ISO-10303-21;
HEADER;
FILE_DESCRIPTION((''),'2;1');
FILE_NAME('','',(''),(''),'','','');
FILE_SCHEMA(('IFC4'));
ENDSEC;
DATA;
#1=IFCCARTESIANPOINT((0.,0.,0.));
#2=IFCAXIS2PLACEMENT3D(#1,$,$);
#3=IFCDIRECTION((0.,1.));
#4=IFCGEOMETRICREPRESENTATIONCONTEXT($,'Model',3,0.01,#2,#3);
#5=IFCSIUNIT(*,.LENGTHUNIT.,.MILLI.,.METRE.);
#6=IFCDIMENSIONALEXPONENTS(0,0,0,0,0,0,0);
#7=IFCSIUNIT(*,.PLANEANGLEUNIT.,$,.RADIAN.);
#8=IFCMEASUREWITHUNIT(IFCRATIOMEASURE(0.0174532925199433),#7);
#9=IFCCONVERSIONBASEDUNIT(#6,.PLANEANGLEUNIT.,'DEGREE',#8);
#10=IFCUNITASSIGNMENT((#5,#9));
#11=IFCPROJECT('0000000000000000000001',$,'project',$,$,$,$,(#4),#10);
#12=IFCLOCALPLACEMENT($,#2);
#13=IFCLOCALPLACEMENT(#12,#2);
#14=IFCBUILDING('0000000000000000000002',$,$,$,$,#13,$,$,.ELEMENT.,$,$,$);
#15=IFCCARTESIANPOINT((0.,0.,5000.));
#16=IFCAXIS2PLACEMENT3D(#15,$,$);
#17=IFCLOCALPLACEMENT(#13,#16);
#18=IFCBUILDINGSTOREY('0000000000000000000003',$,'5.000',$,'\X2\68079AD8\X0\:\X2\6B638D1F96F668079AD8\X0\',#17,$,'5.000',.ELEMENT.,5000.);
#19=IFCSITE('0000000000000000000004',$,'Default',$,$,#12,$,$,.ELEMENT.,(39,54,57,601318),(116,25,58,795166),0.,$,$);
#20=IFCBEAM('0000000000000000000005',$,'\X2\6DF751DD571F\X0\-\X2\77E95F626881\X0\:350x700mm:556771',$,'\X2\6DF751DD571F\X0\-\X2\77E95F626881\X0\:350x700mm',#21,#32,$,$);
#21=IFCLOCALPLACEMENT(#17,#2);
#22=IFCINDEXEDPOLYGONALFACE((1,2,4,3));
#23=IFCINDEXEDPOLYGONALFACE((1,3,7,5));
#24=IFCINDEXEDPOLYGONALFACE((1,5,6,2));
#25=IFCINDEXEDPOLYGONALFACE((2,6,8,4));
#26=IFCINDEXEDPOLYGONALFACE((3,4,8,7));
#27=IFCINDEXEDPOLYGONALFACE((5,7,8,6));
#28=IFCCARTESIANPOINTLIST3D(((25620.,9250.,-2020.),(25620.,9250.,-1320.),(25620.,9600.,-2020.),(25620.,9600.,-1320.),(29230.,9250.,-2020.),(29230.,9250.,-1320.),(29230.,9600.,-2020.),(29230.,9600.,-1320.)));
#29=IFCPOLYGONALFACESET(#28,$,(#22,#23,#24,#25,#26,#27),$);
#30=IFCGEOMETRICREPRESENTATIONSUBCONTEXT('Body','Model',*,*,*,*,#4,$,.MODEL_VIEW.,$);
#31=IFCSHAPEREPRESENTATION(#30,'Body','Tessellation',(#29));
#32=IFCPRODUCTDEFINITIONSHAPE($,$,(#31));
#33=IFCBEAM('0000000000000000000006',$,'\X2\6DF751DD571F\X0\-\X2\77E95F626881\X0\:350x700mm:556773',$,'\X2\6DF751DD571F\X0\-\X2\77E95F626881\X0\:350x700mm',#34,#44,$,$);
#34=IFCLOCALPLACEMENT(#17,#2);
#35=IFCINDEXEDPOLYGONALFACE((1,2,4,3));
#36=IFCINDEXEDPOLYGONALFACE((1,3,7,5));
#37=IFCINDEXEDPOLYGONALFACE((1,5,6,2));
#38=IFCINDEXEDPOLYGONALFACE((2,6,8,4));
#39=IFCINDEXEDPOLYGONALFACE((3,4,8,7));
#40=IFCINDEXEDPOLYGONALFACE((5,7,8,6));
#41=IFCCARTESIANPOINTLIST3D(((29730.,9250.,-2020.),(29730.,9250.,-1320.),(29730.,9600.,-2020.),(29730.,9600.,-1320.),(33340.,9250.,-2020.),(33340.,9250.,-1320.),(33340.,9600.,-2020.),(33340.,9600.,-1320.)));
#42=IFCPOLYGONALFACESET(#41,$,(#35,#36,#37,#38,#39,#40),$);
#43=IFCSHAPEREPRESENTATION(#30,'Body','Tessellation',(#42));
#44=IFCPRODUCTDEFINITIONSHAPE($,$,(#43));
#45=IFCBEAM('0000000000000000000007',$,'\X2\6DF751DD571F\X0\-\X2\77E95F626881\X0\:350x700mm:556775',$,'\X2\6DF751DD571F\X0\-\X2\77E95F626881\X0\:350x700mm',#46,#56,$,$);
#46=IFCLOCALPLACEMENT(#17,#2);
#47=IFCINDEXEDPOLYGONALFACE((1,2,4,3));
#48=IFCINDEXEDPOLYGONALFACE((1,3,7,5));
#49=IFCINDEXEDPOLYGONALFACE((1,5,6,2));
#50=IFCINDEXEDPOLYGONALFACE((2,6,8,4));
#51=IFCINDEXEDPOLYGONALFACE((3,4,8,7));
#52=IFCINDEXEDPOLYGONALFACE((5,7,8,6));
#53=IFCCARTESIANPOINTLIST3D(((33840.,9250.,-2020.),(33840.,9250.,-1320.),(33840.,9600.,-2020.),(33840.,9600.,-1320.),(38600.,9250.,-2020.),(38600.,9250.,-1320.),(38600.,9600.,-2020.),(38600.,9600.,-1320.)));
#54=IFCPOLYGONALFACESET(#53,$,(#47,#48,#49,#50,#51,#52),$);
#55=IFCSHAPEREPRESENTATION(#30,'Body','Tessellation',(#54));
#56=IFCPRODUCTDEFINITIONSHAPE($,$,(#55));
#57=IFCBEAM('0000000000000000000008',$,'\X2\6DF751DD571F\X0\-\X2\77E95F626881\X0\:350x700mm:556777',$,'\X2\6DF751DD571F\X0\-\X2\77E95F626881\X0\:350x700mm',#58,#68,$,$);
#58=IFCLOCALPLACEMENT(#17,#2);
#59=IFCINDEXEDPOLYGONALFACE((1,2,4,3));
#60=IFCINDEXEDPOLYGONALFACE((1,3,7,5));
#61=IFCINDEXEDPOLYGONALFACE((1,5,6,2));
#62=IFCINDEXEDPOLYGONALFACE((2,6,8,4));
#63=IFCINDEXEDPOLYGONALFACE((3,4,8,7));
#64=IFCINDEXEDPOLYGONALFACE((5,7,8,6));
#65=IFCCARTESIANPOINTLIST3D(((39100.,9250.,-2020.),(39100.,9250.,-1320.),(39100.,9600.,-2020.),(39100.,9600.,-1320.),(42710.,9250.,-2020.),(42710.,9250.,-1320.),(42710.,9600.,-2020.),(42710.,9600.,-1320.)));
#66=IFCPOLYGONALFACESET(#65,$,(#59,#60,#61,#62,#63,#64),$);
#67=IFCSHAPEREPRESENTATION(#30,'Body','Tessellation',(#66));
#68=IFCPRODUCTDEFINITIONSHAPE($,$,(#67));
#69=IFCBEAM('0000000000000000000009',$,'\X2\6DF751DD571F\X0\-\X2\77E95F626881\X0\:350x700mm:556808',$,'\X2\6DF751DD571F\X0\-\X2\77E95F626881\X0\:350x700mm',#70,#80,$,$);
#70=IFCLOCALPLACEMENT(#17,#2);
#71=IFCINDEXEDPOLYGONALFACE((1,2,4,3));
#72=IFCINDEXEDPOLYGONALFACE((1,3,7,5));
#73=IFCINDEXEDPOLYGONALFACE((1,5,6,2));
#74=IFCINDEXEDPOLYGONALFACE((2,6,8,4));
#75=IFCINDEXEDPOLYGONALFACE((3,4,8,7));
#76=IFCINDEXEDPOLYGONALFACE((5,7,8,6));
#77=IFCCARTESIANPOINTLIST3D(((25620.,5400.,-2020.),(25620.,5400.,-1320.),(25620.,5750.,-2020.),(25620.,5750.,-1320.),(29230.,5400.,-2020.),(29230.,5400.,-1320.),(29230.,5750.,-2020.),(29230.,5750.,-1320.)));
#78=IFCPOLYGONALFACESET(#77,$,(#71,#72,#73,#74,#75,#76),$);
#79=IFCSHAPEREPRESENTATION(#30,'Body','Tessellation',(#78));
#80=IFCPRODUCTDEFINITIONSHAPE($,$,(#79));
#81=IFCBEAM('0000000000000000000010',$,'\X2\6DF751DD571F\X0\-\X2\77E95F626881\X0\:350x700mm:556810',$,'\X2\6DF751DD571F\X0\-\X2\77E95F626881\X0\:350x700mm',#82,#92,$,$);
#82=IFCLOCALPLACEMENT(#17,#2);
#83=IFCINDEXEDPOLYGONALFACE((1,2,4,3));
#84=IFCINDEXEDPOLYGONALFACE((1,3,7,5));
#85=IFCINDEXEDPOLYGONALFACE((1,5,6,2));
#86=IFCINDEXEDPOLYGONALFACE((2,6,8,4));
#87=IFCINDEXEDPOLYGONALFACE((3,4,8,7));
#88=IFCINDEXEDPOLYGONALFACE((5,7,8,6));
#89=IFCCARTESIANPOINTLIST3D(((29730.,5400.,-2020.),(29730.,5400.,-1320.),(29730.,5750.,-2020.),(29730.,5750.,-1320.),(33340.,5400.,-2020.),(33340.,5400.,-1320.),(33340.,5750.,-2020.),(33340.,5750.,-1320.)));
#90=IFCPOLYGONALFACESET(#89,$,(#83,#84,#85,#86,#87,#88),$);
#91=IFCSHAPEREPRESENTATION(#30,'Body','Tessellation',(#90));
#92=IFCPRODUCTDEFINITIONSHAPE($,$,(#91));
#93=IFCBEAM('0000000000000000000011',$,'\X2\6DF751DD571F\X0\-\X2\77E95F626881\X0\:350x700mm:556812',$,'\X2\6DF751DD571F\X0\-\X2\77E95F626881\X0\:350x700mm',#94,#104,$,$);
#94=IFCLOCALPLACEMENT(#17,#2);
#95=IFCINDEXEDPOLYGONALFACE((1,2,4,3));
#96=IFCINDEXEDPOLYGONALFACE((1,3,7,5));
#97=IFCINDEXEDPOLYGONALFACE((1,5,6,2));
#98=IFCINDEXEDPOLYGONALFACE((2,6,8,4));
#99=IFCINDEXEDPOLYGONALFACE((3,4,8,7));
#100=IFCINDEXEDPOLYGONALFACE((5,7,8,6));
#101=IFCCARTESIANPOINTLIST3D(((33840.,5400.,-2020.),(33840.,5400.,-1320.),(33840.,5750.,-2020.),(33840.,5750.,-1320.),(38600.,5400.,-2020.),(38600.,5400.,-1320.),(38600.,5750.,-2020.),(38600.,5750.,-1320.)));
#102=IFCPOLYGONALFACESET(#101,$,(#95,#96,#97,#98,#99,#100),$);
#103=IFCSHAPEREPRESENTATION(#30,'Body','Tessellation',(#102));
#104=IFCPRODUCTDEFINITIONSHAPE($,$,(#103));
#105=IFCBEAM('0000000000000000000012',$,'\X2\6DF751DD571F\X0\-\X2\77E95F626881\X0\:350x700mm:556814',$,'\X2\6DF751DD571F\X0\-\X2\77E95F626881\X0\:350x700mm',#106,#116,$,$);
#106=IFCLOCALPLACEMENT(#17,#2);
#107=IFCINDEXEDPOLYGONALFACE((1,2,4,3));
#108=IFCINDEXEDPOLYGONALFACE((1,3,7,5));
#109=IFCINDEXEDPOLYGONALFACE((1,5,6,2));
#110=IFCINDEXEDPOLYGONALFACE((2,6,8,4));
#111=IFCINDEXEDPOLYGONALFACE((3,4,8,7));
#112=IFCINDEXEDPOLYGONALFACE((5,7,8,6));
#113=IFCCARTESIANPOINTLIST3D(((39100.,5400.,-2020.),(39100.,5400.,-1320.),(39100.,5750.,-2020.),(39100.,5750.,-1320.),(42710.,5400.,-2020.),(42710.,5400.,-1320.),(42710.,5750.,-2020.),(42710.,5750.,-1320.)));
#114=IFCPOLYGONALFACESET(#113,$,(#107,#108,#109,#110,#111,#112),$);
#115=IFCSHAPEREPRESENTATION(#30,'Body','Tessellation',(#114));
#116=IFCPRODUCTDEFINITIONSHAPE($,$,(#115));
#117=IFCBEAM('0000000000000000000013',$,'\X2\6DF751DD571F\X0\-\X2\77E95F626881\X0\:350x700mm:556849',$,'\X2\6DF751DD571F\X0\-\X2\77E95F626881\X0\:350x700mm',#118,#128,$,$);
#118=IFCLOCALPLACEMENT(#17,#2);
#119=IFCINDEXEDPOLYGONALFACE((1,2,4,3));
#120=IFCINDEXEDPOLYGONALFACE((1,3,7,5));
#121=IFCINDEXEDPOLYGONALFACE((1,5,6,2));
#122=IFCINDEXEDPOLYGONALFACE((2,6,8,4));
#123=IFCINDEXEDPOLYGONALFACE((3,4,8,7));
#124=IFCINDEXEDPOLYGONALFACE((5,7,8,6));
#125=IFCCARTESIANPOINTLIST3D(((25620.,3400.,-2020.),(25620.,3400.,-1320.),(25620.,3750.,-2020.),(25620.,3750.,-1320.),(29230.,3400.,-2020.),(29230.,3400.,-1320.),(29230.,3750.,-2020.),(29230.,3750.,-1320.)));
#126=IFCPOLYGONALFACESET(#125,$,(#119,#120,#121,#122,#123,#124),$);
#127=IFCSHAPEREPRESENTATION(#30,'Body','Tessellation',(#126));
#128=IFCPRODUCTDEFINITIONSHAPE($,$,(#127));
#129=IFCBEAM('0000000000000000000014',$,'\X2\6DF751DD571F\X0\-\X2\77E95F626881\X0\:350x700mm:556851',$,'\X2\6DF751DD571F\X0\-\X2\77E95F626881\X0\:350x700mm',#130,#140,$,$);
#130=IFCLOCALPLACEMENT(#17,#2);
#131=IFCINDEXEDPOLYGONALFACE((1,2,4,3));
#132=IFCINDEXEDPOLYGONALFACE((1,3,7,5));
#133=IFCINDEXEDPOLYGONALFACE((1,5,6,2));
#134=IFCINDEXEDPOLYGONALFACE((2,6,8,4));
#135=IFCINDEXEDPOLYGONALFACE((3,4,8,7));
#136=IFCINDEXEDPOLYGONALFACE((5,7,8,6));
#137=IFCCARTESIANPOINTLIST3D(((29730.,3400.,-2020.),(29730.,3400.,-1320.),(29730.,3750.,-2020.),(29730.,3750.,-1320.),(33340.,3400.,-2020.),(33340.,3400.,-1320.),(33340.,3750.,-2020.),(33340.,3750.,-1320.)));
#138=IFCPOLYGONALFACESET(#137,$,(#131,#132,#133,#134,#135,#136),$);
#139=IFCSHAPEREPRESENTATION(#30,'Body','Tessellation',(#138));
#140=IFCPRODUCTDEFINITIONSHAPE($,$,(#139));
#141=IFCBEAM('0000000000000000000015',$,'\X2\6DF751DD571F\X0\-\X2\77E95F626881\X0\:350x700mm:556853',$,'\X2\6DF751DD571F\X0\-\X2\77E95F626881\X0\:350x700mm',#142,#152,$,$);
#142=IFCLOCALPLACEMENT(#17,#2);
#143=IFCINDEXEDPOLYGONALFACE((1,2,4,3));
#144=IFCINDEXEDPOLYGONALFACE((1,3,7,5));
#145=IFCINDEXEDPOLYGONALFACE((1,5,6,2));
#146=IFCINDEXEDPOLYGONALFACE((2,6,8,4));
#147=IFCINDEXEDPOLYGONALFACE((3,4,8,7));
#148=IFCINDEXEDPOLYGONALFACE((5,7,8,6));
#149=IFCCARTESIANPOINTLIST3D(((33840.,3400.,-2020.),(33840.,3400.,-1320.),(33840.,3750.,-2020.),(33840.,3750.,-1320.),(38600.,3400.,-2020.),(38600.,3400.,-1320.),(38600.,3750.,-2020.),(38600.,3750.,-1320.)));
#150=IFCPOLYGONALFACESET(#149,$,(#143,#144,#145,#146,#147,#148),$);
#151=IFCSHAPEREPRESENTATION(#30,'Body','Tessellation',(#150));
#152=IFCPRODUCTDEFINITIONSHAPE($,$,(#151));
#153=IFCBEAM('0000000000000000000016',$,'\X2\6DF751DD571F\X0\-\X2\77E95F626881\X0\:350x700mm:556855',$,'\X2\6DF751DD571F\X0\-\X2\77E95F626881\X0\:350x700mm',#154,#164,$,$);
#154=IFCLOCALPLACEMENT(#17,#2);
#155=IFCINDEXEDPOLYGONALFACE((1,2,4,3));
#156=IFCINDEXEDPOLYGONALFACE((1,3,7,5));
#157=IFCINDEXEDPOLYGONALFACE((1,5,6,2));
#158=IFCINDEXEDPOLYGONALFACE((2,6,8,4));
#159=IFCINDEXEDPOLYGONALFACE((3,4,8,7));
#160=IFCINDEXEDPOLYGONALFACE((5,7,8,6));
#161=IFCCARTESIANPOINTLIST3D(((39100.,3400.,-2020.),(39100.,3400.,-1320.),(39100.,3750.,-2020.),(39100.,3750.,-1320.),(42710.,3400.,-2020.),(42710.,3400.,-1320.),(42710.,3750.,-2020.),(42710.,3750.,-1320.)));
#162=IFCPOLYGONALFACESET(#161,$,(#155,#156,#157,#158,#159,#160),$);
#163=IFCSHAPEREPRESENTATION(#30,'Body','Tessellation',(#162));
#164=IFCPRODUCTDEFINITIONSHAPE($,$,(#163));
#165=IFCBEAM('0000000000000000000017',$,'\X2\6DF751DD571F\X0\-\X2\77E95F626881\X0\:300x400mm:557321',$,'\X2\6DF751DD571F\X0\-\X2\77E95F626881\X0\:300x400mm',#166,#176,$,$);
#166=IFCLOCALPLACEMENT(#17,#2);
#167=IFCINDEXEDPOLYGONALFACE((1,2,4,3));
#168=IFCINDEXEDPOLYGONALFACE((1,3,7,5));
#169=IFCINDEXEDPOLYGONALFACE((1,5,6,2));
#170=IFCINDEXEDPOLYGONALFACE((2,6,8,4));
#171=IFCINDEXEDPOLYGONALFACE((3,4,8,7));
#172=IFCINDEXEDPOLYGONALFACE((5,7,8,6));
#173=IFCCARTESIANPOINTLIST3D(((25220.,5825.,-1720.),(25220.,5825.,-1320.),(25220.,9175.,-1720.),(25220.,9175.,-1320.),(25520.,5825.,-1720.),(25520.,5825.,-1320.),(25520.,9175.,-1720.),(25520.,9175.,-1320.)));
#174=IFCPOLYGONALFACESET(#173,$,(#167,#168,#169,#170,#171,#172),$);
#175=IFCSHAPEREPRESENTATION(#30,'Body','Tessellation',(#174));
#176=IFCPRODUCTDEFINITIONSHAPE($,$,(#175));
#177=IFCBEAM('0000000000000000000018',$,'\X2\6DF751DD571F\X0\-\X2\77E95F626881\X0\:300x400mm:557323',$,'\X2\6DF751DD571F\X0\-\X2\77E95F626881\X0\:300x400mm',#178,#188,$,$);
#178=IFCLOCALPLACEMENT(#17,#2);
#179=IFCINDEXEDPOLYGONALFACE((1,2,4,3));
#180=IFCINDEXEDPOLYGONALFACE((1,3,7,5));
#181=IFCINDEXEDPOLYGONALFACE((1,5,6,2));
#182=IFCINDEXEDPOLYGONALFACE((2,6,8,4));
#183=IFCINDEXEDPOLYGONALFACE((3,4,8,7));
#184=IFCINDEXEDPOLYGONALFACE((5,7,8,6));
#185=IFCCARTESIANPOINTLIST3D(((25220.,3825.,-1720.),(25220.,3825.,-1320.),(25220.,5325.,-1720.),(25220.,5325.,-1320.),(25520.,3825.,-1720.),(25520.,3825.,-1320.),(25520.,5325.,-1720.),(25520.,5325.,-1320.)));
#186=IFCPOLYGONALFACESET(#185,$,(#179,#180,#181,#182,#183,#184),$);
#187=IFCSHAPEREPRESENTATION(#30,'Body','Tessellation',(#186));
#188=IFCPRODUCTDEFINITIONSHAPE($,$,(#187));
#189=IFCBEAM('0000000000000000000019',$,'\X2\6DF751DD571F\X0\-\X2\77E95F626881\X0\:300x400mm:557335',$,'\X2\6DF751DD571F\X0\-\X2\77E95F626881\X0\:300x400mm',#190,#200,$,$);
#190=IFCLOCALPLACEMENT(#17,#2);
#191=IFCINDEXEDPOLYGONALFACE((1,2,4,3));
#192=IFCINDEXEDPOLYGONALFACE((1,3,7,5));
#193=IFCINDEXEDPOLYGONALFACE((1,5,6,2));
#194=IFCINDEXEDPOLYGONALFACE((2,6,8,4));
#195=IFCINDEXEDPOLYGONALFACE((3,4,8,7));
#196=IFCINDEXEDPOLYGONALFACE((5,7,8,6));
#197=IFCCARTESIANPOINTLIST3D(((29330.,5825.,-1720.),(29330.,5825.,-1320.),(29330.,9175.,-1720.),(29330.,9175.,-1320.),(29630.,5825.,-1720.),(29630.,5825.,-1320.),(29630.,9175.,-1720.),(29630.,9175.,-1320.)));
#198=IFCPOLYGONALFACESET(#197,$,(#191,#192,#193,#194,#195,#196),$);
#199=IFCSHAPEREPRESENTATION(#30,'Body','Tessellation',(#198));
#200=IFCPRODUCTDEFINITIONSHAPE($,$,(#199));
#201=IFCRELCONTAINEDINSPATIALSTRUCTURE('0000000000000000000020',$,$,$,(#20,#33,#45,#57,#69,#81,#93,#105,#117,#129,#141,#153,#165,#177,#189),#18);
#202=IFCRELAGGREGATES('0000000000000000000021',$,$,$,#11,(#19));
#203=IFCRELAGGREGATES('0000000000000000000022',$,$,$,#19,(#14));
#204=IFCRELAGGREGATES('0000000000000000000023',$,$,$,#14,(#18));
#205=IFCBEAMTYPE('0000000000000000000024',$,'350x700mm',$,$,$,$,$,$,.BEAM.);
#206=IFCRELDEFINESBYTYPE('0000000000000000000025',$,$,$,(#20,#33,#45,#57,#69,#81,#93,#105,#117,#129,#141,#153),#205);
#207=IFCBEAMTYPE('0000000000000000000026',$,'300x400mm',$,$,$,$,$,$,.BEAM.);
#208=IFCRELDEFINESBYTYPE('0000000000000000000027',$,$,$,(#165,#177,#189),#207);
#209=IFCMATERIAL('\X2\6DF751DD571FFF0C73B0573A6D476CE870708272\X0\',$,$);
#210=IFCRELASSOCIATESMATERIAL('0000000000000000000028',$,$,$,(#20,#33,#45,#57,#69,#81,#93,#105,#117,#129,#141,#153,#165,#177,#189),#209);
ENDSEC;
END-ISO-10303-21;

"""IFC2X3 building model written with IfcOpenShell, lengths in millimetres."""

from ifc_helpers import new_model, entity, si_unit, converted_unit, direction, frame, frame_2d, origin, place, context, subcontext, project, spatial, rectangle, extrude, material, type_object, element, save


model = new_model("IFC2X3")

# Units and contexts
model_context = context("Model", 3, precision=0.01, world=origin(), true_north=direction((0.0, 1.0)))
body_context = subcontext(model_context, "Body", "Model", "MODEL_VIEW")
ifc_project = project(units=[si_unit("LENGTHUNIT", "METRE", prefix="MILLI"), converted_unit("PLANEANGLEUNIT", "DEGREE", entity("IfcRatioMeasure", 0.0174532925199433), si_unit("PLANEANGLEUNIT", "RADIAN"), dimensions=[0, 0, 0, 0, 0, 0, 0])], contexts=[model_context])

# Site, building, storey
site_placement = place(None, origin())
site = spatial("IfcSite", under=ifc_project, at=site_placement, Name="Default", CompositionType="ELEMENT", RefLatitude=(39, 54, 57, 601318), RefLongitude=(116, 25, 58, 795166), RefElevation=0.0)
building_placement = place(site_placement, origin())
building = spatial("IfcBuilding", under=site, at=building_placement, CompositionType="ELEMENT")
storey_placement = place(building_placement, frame((0.0, 0.0, 5000.0)))
storey = spatial("IfcBuildingStorey", under=building, at=storey_placement, Name="5.000", ObjectType="标高:正负零标高", LongName="5.000", CompositionType="ELEMENT", Elevation=5000.0)

# Beams
ifc_material_1 = material(Name="混凝土，现场浇注灰色")
beam_type_1 = type_object("IfcBeamType", Name="350x700mm", PredefinedType="BEAM")
for number, where, name in (
    (1, (25620.0, 9425.0, -1320.0), "混凝土-矩形梁:350x700mm:556771"),
    (2, (29730.0, 9425.0, -1320.0), "混凝土-矩形梁:350x700mm:556773"),
):
    element("IfcBeam", number, at=place(storey_placement, frame(where)), inside=storey, type_object=beam_type_1, material=ifc_material_1, Name=name, ObjectType="混凝土-矩形梁:350x700mm", context=body_context, shape_type="SweptSolid", body=[
        extrude(rectangle(XDim=700.0, YDim=350.0, at=frame_2d((0.0, 0.0), x_axis=(1.0, 0.0))), frame((0.0, 0.0, -350.0), z_axis=(1.0, 0.0, 0.0), x_axis=(0.0, 0.0, -1.0)), (0.0, 0.0, 1.0), 3610.0),
    ])
beam_1_placement = place(storey_placement, frame((33840.0, 9425.0, -1320.0)))
element("IfcBeam", 3, at=beam_1_placement, inside=storey, type_object=beam_type_1, material=ifc_material_1, Name="混凝土-矩形梁:350x700mm:556775", ObjectType="混凝土-矩形梁:350x700mm", context=body_context, shape_type="SweptSolid", body=[
    extrude(rectangle(XDim=700.0, YDim=350.0, at=frame_2d((0.0, 0.0), x_axis=(1.0, 0.0))), frame((0.0, 0.0, -350.0), z_axis=(1.0, 0.0, 0.0), x_axis=(0.0, 0.0, -1.0)), (0.0, 0.0, 1.0), 4760.0),
])
beam_2_placement = place(storey_placement, frame((39100.0, 9425.0, -1320.0)))
element("IfcBeam", 4, at=beam_2_placement, inside=storey, type_object=beam_type_1, material=ifc_material_1, Name="混凝土-矩形梁:350x700mm:556777", ObjectType="混凝土-矩形梁:350x700mm", context=body_context, shape_type="SweptSolid", body=[
    extrude(rectangle(XDim=700.0, YDim=350.0, at=frame_2d((0.0, 0.0), x_axis=(1.0, 0.0))), frame((0.0, 0.0, -350.0), z_axis=(1.0, 0.0, 0.0), x_axis=(0.0, 0.0, -1.0)), (0.0, 0.0, 1.0), 3610.0),
])
for number, where, name in (
    (5, (25620.0, 5575.0, -1320.0), "混凝土-矩形梁:350x700mm:556808"),
    (6, (29730.0, 5575.0, -1320.0), "混凝土-矩形梁:350x700mm:556810"),
):
    element("IfcBeam", number, at=place(storey_placement, frame(where)), inside=storey, type_object=beam_type_1, material=ifc_material_1, Name=name, ObjectType="混凝土-矩形梁:350x700mm", context=body_context, shape_type="SweptSolid", body=[
        extrude(rectangle(XDim=700.0, YDim=350.0, at=frame_2d((0.0, 0.0), x_axis=(1.0, 0.0))), frame((0.0, 0.0, -350.0), z_axis=(1.0, 0.0, 0.0), x_axis=(0.0, 0.0, -1.0)), (0.0, 0.0, 1.0), 3610.0),
    ])
beam_3_placement = place(storey_placement, frame((33840.0, 5575.0, -1320.0)))
element("IfcBeam", 7, at=beam_3_placement, inside=storey, type_object=beam_type_1, material=ifc_material_1, Name="混凝土-矩形梁:350x700mm:556812", ObjectType="混凝土-矩形梁:350x700mm", context=body_context, shape_type="SweptSolid", body=[
    extrude(rectangle(XDim=700.0, YDim=350.0, at=frame_2d((0.0, 0.0), x_axis=(1.0, 0.0))), frame((0.0, 0.0, -350.0), z_axis=(1.0, 0.0, 0.0), x_axis=(0.0, 0.0, -1.0)), (0.0, 0.0, 1.0), 4760.0),
])
beam_4_placement = place(storey_placement, frame((39100.0, 5575.0, -1320.0)))
element("IfcBeam", 8, at=beam_4_placement, inside=storey, type_object=beam_type_1, material=ifc_material_1, Name="混凝土-矩形梁:350x700mm:556814", ObjectType="混凝土-矩形梁:350x700mm", context=body_context, shape_type="SweptSolid", body=[
    extrude(rectangle(XDim=700.0, YDim=350.0, at=frame_2d((0.0, 0.0), x_axis=(1.0, 0.0))), frame((0.0, 0.0, -350.0), z_axis=(1.0, 0.0, 0.0), x_axis=(0.0, 0.0, -1.0)), (0.0, 0.0, 1.0), 3610.0),
])
for number, where, name in (
    (9, (25620.0, 3575.0, -1320.0), "混凝土-矩形梁:350x700mm:556849"),
    (10, (29730.0, 3575.0, -1320.0), "混凝土-矩形梁:350x700mm:556851"),
):
    element("IfcBeam", number, at=place(storey_placement, frame(where)), inside=storey, type_object=beam_type_1, material=ifc_material_1, Name=name, ObjectType="混凝土-矩形梁:350x700mm", context=body_context, shape_type="SweptSolid", body=[
        extrude(rectangle(XDim=700.0, YDim=350.0, at=frame_2d((0.0, 0.0), x_axis=(1.0, 0.0))), frame((0.0, 0.0, -350.0), z_axis=(1.0, 0.0, 0.0), x_axis=(0.0, 0.0, -1.0)), (0.0, 0.0, 1.0), 3610.0),
    ])
beam_5_placement = place(storey_placement, frame((33840.0, 3575.0, -1320.0)))
element("IfcBeam", 11, at=beam_5_placement, inside=storey, type_object=beam_type_1, material=ifc_material_1, Name="混凝土-矩形梁:350x700mm:556853", ObjectType="混凝土-矩形梁:350x700mm", context=body_context, shape_type="SweptSolid", body=[
    extrude(rectangle(XDim=700.0, YDim=350.0, at=frame_2d((0.0, 0.0), x_axis=(1.0, 0.0))), frame((0.0, 0.0, -350.0), z_axis=(1.0, 0.0, 0.0), x_axis=(0.0, 0.0, -1.0)), (0.0, 0.0, 1.0), 4760.0),
])
beam_6_placement = place(storey_placement, frame((39100.0, 3575.0, -1320.0)))
element("IfcBeam", 12, at=beam_6_placement, inside=storey, type_object=beam_type_1, material=ifc_material_1, Name="混凝土-矩形梁:350x700mm:556855", ObjectType="混凝土-矩形梁:350x700mm", context=body_context, shape_type="SweptSolid", body=[
    extrude(rectangle(XDim=700.0, YDim=350.0, at=frame_2d((0.0, 0.0), x_axis=(1.0, 0.0))), frame((0.0, 0.0, -350.0), z_axis=(1.0, 0.0, 0.0), x_axis=(0.0, 0.0, -1.0)), (0.0, 0.0, 1.0), 3610.0),
])
beam_type_2 = type_object("IfcBeamType", Name="300x400mm", PredefinedType="BEAM")
beam_7_placement = place(storey_placement, frame((25370.0, 9175.0, -1320.0), z_axis=(0.0, 0.0, 1.0), x_axis=(0.0, -1.0, 0.0)))
element("IfcBeam", 13, at=beam_7_placement, inside=storey, type_object=beam_type_2, material=ifc_material_1, Name="混凝土-矩形梁:300x400mm:557321", ObjectType="混凝土-矩形梁:300x400mm", context=body_context, shape_type="SweptSolid", body=[
    extrude(rectangle(XDim=400.0, YDim=300.0, at=frame_2d((0.0, 0.0), x_axis=(1.0, 0.0))), frame((0.0, 0.0, -200.0), z_axis=(1.0, 0.0, 0.0), x_axis=(0.0, 0.0, -1.0)), (0.0, 0.0, 1.0), 3350.0),
])
beam_8_placement = place(storey_placement, frame((25370.0, 5325.0, -1320.0), z_axis=(0.0, 0.0, 1.0), x_axis=(0.0, -1.0, 0.0)))
element("IfcBeam", 14, at=beam_8_placement, inside=storey, type_object=beam_type_2, material=ifc_material_1, Name="混凝土-矩形梁:300x400mm:557323", ObjectType="混凝土-矩形梁:300x400mm", context=body_context, shape_type="SweptSolid", body=[
    extrude(rectangle(XDim=400.0, YDim=300.0, at=frame_2d((0.0, 0.0), x_axis=(1.0, 0.0))), frame((0.0, 0.0, -200.0), z_axis=(1.0, 0.0, 0.0), x_axis=(0.0, 0.0, -1.0)), (0.0, 0.0, 1.0), 1500.0),
])
beam_9_placement = place(storey_placement, frame((29480.0, 9175.0, -1320.0), z_axis=(0.0, 0.0, 1.0), x_axis=(0.0, -1.0, 0.0)))
element("IfcBeam", 15, at=beam_9_placement, inside=storey, type_object=beam_type_2, material=ifc_material_1, Name="混凝土-矩形梁:300x400mm:557335", ObjectType="混凝土-矩形梁:300x400mm", context=body_context, shape_type="SweptSolid", body=[
    extrude(rectangle(XDim=400.0, YDim=300.0, at=frame_2d((0.0, 0.0), x_axis=(1.0, 0.0))), frame((0.0, 0.0, -200.0), z_axis=(1.0, 0.0, 0.0), x_axis=(0.0, 0.0, -1.0)), (0.0, 0.0, 1.0), 3350.0),
])

save(model, "model.ifc")
